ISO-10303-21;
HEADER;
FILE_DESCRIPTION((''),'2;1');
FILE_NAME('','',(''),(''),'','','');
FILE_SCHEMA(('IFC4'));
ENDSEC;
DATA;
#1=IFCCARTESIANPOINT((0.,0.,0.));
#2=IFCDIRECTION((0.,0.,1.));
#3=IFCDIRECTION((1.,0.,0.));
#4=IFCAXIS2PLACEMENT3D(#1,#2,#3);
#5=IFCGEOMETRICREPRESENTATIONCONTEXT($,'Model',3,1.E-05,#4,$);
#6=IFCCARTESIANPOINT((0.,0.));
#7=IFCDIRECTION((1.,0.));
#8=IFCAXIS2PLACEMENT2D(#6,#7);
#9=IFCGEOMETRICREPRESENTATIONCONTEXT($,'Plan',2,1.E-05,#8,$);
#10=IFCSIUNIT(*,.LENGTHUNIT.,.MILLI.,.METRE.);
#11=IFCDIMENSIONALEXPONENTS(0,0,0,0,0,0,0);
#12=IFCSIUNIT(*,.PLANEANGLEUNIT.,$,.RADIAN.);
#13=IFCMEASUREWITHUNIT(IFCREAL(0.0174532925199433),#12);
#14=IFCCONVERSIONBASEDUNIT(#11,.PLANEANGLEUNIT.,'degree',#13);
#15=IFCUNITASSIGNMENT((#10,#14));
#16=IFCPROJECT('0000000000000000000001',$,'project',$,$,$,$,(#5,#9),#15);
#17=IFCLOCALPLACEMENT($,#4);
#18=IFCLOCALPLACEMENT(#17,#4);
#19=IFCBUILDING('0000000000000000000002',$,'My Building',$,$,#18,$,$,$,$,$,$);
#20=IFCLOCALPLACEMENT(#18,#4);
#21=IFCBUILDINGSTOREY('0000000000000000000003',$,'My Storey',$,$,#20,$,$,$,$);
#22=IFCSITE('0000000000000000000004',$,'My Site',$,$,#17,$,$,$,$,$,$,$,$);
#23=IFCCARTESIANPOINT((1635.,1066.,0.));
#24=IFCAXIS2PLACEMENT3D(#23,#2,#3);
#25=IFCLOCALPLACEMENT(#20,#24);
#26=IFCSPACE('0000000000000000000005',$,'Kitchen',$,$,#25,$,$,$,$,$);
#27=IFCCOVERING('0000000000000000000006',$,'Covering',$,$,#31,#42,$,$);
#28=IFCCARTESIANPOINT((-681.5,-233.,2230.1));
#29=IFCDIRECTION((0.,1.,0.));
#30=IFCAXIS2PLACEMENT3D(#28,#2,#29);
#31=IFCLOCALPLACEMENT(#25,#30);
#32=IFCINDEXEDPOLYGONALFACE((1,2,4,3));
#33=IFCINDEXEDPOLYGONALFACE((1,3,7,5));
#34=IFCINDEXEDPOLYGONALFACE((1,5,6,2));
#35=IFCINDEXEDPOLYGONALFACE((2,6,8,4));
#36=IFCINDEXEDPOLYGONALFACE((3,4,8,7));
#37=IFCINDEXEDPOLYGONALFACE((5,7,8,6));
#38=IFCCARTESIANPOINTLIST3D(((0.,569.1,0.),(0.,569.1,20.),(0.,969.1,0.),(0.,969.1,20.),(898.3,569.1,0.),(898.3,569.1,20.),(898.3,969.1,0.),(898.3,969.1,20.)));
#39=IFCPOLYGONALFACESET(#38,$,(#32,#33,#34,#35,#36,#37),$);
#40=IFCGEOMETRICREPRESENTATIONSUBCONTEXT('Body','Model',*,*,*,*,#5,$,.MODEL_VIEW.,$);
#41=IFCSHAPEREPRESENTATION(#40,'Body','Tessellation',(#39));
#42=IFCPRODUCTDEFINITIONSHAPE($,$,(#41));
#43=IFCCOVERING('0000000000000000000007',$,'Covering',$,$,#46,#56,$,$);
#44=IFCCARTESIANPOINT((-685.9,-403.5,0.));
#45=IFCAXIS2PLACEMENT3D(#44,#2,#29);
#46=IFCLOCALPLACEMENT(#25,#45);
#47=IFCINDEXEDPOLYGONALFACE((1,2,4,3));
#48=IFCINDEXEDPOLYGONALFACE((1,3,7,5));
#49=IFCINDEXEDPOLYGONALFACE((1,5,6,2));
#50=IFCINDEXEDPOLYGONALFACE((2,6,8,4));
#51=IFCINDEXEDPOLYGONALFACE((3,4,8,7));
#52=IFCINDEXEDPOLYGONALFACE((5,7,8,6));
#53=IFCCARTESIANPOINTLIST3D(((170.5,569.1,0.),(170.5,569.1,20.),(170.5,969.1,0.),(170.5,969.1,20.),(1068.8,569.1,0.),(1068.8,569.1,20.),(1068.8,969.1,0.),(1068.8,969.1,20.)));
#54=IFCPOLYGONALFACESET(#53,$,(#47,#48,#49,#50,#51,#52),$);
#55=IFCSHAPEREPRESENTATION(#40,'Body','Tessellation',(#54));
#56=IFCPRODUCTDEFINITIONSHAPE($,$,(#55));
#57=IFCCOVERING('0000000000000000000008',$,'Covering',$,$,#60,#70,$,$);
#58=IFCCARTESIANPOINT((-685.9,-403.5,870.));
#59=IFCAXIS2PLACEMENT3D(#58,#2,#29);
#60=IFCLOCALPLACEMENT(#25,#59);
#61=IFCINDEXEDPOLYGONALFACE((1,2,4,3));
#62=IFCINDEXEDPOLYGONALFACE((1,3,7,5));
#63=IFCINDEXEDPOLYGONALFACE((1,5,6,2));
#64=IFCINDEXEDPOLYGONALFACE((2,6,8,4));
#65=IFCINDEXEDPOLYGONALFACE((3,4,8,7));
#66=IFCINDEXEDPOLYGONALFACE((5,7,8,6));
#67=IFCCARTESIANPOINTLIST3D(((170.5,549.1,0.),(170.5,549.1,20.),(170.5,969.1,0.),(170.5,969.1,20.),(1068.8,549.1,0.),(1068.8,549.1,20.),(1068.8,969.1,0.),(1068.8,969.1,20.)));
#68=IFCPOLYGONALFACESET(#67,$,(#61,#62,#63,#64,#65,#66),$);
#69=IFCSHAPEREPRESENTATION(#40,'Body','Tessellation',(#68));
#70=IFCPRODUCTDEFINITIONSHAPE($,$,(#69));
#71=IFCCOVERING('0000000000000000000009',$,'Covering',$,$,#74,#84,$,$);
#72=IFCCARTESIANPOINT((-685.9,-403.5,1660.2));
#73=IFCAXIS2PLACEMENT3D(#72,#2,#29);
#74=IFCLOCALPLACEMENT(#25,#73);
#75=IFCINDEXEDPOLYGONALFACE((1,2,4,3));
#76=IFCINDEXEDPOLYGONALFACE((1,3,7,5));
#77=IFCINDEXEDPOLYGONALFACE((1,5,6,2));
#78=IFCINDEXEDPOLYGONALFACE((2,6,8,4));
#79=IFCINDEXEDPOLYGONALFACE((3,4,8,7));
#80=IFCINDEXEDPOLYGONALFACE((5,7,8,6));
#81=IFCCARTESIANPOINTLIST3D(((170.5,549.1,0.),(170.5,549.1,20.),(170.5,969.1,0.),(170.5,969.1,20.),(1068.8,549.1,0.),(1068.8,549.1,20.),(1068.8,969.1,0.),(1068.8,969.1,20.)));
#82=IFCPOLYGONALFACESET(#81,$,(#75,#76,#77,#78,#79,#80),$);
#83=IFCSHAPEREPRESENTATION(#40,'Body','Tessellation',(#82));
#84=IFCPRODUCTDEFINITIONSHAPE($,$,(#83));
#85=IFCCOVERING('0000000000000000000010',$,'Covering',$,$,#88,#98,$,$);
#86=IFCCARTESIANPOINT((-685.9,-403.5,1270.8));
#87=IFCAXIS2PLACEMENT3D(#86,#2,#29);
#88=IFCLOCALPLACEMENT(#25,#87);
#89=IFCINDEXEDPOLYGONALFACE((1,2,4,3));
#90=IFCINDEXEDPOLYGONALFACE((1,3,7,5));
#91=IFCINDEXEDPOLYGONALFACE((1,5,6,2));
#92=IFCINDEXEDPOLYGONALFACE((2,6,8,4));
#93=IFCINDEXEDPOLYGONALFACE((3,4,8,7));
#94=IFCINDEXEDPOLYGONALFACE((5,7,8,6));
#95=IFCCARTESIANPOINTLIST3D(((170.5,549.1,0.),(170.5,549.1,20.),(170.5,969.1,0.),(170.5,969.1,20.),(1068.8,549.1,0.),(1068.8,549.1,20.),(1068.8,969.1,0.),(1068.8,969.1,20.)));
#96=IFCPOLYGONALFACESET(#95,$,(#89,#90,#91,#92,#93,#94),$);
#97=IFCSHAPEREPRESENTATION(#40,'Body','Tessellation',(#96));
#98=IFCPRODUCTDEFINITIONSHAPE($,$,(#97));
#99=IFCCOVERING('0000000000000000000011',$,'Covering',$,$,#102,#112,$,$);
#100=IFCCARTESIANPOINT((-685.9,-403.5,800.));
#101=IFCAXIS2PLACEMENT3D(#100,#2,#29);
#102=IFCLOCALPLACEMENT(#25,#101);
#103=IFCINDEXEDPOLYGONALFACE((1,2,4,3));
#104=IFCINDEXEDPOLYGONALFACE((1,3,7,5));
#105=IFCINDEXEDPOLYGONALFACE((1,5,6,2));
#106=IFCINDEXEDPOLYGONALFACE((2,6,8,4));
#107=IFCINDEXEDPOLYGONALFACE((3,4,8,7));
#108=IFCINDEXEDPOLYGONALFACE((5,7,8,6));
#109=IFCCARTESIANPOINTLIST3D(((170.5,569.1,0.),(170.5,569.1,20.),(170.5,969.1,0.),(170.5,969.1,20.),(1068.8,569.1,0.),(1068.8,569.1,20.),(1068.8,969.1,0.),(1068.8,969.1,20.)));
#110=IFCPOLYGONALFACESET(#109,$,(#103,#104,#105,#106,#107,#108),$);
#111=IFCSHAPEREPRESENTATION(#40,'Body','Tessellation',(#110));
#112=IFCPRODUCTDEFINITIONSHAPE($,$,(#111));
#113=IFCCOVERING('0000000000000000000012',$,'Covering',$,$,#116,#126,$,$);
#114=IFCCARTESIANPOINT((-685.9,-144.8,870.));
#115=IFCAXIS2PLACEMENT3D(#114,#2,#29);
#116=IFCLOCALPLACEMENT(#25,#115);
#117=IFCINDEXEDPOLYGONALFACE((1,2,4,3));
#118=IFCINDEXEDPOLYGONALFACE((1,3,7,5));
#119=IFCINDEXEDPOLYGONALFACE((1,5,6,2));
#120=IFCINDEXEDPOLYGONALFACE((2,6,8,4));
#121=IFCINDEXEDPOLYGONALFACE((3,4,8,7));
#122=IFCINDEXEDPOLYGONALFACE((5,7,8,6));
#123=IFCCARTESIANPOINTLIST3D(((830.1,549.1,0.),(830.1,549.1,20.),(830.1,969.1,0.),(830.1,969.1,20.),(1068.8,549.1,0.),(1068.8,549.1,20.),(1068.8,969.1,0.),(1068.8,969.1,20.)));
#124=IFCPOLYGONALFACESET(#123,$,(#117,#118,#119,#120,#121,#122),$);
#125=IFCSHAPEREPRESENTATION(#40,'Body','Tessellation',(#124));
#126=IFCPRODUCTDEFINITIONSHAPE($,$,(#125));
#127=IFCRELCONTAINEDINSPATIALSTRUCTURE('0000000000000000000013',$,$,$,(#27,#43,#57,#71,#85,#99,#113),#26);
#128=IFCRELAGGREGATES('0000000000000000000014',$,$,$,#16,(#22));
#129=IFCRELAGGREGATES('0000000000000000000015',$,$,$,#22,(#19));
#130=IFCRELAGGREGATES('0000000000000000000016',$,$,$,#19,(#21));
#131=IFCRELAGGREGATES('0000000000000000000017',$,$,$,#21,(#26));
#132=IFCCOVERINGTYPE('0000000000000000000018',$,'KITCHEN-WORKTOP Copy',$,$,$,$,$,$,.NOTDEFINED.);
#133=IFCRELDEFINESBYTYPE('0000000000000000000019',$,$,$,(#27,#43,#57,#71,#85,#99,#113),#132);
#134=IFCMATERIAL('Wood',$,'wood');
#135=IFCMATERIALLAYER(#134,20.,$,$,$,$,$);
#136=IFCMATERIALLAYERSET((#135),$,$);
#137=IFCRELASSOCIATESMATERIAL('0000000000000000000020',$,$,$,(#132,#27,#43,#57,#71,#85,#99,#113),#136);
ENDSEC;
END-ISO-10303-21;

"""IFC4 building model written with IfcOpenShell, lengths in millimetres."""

from ifc_helpers import new_model, entity, si_unit, converted_unit, frame, origin_with_axes, origin_2d_with_axis, place, context, subcontext, project, spatial, line, indexed_curve, outline, extrude, material, layer, layer_set, layer_usage, type_object, element, save


model = new_model("IFC4")

# Units and contexts
model_context = context("Model", 3, precision=1e-05, world=origin_with_axes())
plan_context = context("Plan", 2, precision=1e-05, world=origin_2d_with_axis())
body_context = subcontext(model_context, "Body", "Model", "MODEL_VIEW")
ifc_project = project(units=[si_unit("LENGTHUNIT", "METRE", prefix="MILLI"), converted_unit("PLANEANGLEUNIT", "degree", entity("IfcReal", 0.0174532925199433), si_unit("PLANEANGLEUNIT", "RADIAN"), dimensions=[0, 0, 0, 0, 0, 0, 0])], contexts=[model_context, plan_context])

# Site, building, storey
site_placement = place(None, origin_with_axes())
site = spatial("IfcSite", under=ifc_project, at=site_placement, Name="My Site")
building_placement = place(site_placement, origin_with_axes())
building = spatial("IfcBuilding", under=site, at=building_placement, Name="My Building")
storey_placement = place(building_placement, origin_with_axes())
storey = spatial("IfcBuildingStorey", under=building, at=storey_placement, Name="My Storey")

# Shared definitions
space_1_placement = place(storey_placement, frame((1635.0, 1066.0, 0.0), z_axis=(0.0, 0.0, 1.0), x_axis=(1.0, 0.0, 0.0)))
space_1 = spatial("IfcSpace", under=storey, at=space_1_placement, Name="Kitchen")

# Coverings
ifc_material_1 = material(Name="Wood", Category="wood")
ifc_layer_1 = layer(ifc_material_1, 20.0)
ifc_layer_set_1 = layer_set([ifc_layer_1])
ifc_layer_usage_1 = layer_usage(ifc_layer_set_1, "AXIS3", "POSITIVE", 0.0)
covering_type_1 = type_object("IfcCoveringType", Name="KITCHEN-WORKTOP Copy", PredefinedType="NOTDEFINED", material=ifc_layer_set_1)
covering_1_placement = place(space_1_placement, frame((-681.5, -233.0, 2230.1), z_axis=(0.0, 0.0, 1.0), x_axis=(0.0, 1.0, 0.0)))
element("IfcCovering", 1, at=covering_1_placement, inside=space_1, type_object=covering_type_1, material=ifc_layer_usage_1, Name="Covering", context=body_context, shape_type="SweptSolid", body=[
    extrude(outline(indexed_curve([(0.0, 569.1), (0.0, 969.1), (898.3, 969.1), (898.3, 569.1)], segments=[line(4, 1), line(1, 2), line(2, 3), line(3, 4)], self_intersect=False)), None, (0.0, 0.0, 1.0), 20.0),
])
ifc_layer_usage_2 = layer_usage(ifc_layer_set_1, "AXIS3", "POSITIVE", 0.0)
covering_2_placement = place(space_1_placement, frame((-685.9, -403.5, 0.0), z_axis=(0.0, 0.0, 1.0), x_axis=(0.0, 1.0, 0.0)))
element("IfcCovering", 2, at=covering_2_placement, inside=space_1, type_object=covering_type_1, material=ifc_layer_usage_2, Name="Covering", context=body_context, shape_type="SweptSolid", body=[
    extrude(outline(indexed_curve([(170.5, 569.1), (170.5, 969.1), (1068.8, 969.1), (1068.8, 569.1)], segments=[line(4, 1), line(1, 2), line(2, 3), line(3, 4)], self_intersect=False)), None, (0.0, 0.0, 1.0), 20.0),
])
ifc_layer_usage_3 = layer_usage(ifc_layer_set_1, "AXIS3", "POSITIVE", 0.0)
covering_3_placement = place(space_1_placement, frame((-685.9, -403.5, 870.0), z_axis=(0.0, 0.0, 1.0), x_axis=(0.0, 1.0, 0.0)))
element("IfcCovering", 3, at=covering_3_placement, inside=space_1, type_object=covering_type_1, material=ifc_layer_usage_3, Name="Covering", context=body_context, shape_type="SweptSolid", body=[
    extrude(outline(indexed_curve([(1068.8, 549.1), (170.5, 549.1), (170.5, 969.1), (1068.8, 969.1)], segments=[line(3, 2), line(2, 1), line(1, 4), line(4, 3)], self_intersect=False)), None, (0.0, 0.0, 1.0), 20.0),
])
ifc_layer_usage_4 = layer_usage(ifc_layer_set_1, "AXIS3", "POSITIVE", 0.0)
covering_4_placement = place(space_1_placement, frame((-685.9, -403.5, 1660.2), z_axis=(0.0, 0.0, 1.0), x_axis=(0.0, 1.0, 0.0)))
element("IfcCovering", 4, at=covering_4_placement, inside=space_1, type_object=covering_type_1, material=ifc_layer_usage_4, Name="Covering", context=body_context, shape_type="SweptSolid", body=[
    extrude(outline(indexed_curve([(1068.8, 549.1), (170.5, 549.1), (170.5, 969.1), (1068.8, 969.1)], segments=[line(3, 2), line(2, 1), line(1, 4), line(4, 3)], self_intersect=False)), None, (0.0, 0.0, 1.0), 20.0),
])
ifc_layer_usage_5 = layer_usage(ifc_layer_set_1, "AXIS3", "POSITIVE", 0.0)
covering_5_placement = place(space_1_placement, frame((-685.9, -403.5, 1270.8), z_axis=(0.0, 0.0, 1.0), x_axis=(0.0, 1.0, 0.0)))
element("IfcCovering", 5, at=covering_5_placement, inside=space_1, type_object=covering_type_1, material=ifc_layer_usage_5, Name="Covering", context=body_context, shape_type="SweptSolid", body=[
    extrude(outline(indexed_curve([(1068.8, 549.1), (170.5, 549.1), (170.5, 969.1), (1068.8, 969.1)], segments=[line(4, 1), line(1, 2), line(2, 3), line(3, 4)], self_intersect=False)), None, (0.0, 0.0, 1.0), 20.0),
])
ifc_layer_usage_6 = layer_usage(ifc_layer_set_1, "AXIS3", "POSITIVE", 0.0)
covering_6_placement = place(space_1_placement, frame((-685.9, -403.5, 800.0), z_axis=(0.0, 0.0, 1.0), x_axis=(0.0, 1.0, 0.0)))
element("IfcCovering", 6, at=covering_6_placement, inside=space_1, type_object=covering_type_1, material=ifc_layer_usage_6, Name="Covering", context=body_context, shape_type="SweptSolid", body=[
    extrude(outline(indexed_curve([(170.5, 569.1), (170.5, 969.1), (1068.8, 969.1), (1068.8, 569.1)], segments=[line(4, 1), line(1, 2), line(2, 3), line(3, 4)], self_intersect=False)), None, (0.0, 0.0, 1.0), 20.0),
])
ifc_layer_usage_7 = layer_usage(ifc_layer_set_1, "AXIS3", "POSITIVE", 0.0)
covering_7_placement = place(space_1_placement, frame((-685.9, -144.8, 870.0), z_axis=(0.0, 0.0, 1.0), x_axis=(0.0, 1.0, 0.0)))
element("IfcCovering", 7, at=covering_7_placement, inside=space_1, type_object=covering_type_1, material=ifc_layer_usage_7, Name="Covering", context=body_context, shape_type="SweptSolid", body=[
    extrude(outline(indexed_curve([(1068.8, 969.1), (830.1, 969.1), (830.1, 549.1), (1068.8, 549.1)], segments=[line(3, 2), line(2, 1), line(1, 4), line(4, 3)], self_intersect=False)), None, (0.0, 0.0, 1.0), 20.0),
])

save(model, "model.ifc")
